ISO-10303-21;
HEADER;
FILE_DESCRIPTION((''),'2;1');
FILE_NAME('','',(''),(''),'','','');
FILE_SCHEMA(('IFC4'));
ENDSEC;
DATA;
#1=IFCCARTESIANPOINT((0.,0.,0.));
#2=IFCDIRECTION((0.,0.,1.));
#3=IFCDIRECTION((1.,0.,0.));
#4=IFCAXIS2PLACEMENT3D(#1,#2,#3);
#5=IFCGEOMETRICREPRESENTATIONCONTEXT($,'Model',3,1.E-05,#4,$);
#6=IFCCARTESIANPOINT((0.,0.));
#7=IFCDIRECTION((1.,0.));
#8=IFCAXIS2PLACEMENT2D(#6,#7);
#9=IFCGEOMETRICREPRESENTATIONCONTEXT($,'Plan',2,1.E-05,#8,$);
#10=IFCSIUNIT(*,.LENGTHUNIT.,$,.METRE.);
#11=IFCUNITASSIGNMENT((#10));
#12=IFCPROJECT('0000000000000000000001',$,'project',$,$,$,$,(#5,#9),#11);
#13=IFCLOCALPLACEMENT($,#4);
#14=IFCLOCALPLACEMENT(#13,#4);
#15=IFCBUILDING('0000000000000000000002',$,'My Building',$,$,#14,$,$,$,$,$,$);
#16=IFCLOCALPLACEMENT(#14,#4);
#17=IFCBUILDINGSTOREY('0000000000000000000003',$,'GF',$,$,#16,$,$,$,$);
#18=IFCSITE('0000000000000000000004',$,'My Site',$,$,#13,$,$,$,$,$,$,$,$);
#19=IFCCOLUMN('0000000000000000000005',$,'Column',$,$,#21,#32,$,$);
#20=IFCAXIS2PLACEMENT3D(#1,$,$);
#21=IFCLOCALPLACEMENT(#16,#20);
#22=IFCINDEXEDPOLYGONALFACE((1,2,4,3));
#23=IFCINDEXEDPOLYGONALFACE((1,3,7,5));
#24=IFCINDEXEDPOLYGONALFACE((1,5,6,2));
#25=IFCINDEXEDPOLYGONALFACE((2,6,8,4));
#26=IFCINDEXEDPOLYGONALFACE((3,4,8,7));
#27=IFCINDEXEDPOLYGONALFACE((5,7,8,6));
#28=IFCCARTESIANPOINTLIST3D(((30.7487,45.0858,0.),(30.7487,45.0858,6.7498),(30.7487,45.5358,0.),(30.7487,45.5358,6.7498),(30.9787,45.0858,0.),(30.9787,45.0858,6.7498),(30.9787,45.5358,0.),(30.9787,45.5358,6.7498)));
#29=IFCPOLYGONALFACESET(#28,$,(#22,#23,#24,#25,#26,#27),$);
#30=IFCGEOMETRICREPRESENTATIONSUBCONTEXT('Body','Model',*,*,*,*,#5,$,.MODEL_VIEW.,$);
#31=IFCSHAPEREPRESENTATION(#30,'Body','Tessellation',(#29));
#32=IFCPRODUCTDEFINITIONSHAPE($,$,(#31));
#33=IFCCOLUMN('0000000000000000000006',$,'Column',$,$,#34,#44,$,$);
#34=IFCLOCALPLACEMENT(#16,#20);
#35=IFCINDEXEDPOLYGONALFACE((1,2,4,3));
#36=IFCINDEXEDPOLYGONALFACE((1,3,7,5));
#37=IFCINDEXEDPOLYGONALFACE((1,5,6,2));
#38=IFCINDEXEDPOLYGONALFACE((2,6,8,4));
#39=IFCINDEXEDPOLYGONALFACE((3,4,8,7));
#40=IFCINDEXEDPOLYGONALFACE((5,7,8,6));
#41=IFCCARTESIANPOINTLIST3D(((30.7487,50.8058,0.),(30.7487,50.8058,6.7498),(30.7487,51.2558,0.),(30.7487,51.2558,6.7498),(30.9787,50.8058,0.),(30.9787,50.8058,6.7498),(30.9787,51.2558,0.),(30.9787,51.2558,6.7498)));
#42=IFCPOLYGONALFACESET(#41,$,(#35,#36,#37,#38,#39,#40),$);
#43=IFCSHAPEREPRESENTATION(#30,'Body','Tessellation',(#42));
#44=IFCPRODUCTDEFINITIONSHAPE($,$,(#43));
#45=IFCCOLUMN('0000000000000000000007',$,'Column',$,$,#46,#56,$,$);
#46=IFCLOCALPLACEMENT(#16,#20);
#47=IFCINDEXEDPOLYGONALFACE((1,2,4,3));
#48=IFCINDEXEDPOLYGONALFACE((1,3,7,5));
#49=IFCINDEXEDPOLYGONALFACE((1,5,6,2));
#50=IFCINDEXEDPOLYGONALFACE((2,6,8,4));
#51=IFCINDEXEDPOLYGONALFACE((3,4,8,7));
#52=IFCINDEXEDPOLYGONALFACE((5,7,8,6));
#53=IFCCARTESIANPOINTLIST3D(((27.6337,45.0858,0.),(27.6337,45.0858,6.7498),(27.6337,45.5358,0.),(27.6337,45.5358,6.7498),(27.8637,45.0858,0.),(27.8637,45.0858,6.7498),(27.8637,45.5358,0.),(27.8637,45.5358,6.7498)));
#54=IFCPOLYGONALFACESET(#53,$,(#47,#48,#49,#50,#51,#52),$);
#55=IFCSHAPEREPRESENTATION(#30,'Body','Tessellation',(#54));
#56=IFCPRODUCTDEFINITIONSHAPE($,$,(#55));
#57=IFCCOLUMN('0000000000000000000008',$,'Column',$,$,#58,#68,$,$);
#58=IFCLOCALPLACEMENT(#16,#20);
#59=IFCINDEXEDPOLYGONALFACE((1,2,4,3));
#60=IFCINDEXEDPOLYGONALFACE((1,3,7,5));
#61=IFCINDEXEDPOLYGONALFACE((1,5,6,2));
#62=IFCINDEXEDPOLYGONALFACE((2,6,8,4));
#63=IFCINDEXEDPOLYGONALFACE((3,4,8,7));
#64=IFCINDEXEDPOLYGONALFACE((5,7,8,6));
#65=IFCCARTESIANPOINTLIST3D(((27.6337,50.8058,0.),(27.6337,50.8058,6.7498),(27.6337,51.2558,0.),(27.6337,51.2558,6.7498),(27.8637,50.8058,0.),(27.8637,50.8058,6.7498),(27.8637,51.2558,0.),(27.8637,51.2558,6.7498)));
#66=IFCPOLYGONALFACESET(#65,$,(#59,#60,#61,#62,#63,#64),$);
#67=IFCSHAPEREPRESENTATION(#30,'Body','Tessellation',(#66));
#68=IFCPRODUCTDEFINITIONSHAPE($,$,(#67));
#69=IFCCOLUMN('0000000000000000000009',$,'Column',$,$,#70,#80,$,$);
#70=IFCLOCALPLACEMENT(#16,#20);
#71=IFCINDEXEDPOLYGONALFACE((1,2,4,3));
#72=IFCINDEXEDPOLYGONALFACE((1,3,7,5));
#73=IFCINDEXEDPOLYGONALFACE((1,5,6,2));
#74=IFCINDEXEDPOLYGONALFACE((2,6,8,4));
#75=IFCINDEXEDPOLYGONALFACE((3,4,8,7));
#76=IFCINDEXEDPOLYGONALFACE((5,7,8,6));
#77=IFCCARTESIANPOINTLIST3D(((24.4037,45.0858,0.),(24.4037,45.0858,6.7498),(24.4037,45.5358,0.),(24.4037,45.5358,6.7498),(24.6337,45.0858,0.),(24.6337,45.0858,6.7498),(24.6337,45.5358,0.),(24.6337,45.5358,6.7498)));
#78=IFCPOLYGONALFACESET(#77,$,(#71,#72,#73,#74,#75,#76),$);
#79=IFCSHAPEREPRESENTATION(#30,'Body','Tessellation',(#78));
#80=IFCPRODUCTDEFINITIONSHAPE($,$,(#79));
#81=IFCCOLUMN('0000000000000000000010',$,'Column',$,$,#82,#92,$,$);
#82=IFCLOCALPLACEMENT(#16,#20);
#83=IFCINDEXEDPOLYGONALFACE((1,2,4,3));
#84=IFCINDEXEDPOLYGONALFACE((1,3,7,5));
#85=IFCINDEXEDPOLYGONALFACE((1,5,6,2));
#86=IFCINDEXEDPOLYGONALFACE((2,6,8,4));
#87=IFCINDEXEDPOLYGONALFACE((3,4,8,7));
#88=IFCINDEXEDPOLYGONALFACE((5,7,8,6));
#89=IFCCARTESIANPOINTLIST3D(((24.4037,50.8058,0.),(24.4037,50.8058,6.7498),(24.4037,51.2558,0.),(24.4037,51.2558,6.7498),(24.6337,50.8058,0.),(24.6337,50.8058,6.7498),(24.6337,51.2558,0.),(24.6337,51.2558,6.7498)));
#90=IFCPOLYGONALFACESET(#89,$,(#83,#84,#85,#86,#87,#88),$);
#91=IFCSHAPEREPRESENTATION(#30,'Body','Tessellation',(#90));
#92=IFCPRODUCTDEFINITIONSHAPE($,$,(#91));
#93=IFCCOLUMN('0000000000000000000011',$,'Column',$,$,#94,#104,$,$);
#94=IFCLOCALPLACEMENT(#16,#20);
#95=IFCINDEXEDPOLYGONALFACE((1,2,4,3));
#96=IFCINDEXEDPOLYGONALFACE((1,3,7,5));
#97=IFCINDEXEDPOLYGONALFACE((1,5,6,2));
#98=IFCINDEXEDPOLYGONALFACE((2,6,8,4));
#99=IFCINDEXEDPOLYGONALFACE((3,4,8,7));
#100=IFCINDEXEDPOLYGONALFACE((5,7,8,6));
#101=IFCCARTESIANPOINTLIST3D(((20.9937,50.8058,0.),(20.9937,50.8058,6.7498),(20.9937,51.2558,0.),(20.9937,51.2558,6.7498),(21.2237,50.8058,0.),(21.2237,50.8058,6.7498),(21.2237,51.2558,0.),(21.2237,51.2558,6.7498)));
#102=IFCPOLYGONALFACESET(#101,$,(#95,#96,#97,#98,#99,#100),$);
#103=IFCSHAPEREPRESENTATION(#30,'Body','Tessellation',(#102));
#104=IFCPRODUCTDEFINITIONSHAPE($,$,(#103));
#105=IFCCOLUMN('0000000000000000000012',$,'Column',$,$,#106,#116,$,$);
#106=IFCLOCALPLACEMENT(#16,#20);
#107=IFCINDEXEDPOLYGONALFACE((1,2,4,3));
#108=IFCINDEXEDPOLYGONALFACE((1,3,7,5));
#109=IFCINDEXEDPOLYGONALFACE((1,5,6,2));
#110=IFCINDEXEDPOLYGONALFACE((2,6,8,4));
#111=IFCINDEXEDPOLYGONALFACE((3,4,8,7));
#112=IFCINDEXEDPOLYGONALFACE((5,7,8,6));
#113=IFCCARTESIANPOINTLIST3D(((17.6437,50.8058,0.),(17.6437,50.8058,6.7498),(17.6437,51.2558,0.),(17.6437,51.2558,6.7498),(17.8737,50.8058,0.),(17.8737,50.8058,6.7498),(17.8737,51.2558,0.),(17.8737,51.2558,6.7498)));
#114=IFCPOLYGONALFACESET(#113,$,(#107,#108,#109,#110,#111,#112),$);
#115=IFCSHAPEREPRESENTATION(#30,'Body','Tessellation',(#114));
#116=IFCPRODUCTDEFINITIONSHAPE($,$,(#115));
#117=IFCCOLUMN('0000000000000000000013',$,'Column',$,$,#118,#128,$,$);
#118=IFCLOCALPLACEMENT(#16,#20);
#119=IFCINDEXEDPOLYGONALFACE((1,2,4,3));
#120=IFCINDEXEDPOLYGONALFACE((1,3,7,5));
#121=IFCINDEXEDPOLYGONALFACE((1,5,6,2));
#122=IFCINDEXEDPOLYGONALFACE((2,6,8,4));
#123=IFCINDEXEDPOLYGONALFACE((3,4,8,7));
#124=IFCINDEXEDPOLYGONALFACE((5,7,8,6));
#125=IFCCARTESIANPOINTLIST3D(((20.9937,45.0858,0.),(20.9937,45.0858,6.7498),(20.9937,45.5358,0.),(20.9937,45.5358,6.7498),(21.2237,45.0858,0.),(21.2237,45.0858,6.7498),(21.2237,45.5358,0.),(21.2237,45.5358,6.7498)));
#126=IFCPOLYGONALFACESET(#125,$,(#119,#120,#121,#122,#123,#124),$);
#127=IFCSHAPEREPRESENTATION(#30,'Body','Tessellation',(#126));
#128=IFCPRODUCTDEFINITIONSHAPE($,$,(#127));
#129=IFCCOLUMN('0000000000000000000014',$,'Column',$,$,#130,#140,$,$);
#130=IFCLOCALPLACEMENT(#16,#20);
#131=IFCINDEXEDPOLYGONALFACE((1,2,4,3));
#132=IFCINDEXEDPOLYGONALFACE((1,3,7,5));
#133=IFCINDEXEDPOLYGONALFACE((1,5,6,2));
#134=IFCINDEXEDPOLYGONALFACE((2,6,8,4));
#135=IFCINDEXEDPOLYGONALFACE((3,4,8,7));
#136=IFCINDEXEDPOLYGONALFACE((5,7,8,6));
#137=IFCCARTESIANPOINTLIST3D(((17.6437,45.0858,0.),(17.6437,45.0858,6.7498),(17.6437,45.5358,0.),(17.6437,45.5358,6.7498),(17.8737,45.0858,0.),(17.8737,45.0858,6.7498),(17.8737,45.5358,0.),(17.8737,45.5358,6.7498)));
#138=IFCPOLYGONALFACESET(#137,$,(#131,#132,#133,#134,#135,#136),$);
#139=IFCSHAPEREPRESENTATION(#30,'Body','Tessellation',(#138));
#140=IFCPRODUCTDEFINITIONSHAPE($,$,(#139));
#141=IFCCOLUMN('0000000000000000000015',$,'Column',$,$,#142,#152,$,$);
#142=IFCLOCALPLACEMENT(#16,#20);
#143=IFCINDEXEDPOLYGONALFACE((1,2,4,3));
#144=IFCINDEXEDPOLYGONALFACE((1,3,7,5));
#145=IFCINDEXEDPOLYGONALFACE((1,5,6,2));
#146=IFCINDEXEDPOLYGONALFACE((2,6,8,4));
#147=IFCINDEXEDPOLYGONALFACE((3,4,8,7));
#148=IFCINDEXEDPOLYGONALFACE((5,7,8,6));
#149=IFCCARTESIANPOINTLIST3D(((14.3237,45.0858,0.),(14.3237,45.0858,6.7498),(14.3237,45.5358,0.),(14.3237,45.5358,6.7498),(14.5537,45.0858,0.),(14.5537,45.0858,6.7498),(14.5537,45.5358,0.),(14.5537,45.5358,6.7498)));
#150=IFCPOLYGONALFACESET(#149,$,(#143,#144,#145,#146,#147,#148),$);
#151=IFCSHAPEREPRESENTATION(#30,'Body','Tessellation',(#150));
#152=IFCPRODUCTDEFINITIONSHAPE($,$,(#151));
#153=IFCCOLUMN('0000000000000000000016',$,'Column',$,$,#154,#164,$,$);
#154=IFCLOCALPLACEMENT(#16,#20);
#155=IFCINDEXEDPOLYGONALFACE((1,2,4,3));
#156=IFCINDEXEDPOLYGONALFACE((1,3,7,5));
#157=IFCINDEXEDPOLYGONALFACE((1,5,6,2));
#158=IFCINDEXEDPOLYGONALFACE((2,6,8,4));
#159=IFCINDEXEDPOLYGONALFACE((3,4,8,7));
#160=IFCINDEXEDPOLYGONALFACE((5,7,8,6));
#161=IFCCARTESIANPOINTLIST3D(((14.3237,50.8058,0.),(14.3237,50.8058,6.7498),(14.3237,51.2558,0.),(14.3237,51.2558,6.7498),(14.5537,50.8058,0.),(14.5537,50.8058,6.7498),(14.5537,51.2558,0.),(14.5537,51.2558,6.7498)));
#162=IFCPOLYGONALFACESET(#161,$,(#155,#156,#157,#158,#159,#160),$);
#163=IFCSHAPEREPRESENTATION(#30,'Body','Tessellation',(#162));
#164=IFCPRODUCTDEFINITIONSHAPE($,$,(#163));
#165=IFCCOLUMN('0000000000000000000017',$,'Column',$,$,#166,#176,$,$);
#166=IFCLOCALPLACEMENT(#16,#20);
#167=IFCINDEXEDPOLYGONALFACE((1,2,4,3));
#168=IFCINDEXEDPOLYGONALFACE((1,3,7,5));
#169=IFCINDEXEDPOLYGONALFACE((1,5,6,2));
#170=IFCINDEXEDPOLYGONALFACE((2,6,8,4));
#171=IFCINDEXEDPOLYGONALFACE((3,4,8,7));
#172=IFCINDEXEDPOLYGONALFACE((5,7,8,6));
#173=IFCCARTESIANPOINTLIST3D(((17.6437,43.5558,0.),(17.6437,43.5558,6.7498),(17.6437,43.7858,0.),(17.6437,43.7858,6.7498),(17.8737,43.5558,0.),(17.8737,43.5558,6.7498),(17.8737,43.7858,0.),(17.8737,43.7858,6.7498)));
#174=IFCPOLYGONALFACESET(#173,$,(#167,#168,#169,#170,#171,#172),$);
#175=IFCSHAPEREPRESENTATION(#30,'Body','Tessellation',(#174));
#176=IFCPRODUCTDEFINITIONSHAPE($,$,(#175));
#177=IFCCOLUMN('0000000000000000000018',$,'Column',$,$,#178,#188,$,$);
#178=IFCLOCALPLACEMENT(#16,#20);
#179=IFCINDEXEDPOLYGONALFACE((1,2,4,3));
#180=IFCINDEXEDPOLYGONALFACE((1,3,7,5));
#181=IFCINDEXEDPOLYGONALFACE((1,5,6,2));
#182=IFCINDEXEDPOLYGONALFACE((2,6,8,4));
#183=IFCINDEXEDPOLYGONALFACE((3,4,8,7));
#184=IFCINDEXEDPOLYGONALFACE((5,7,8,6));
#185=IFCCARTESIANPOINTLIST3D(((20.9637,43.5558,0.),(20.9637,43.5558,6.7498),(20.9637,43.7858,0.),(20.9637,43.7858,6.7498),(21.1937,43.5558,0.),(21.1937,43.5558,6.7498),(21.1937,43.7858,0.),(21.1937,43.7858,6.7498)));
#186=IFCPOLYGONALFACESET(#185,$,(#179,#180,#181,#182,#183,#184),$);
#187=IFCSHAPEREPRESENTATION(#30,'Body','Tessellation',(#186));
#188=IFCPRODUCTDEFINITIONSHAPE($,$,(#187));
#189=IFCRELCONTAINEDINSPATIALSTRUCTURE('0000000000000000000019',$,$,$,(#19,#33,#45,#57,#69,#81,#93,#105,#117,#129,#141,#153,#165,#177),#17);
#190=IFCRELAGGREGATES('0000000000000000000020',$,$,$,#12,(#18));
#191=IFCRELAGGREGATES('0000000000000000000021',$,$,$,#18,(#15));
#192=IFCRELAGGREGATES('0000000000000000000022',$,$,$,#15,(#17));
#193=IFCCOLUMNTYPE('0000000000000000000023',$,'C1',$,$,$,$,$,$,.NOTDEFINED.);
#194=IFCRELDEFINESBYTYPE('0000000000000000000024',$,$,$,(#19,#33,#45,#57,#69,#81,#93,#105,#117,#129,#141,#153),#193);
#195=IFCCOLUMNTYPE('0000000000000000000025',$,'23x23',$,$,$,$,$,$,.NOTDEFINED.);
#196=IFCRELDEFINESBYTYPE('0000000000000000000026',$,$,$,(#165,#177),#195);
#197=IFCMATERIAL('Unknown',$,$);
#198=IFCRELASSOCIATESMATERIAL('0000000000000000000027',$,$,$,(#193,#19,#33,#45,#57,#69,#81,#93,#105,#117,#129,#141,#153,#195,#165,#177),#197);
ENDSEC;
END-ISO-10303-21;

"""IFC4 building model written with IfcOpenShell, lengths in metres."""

from ifc_helpers import new_model, si_unit, frame, origin_with_axes, origin_2d_with_axis, place, context, subcontext, project, spatial, rectangle, extrude, material, material_profile, profile_set, profile_usage, type_object, element, save


model = new_model("IFC4")

# Units and contexts
model_context = context("Model", 3, precision=1e-05, world=origin_with_axes())
plan_context = context("Plan", 2, precision=1e-05, world=origin_2d_with_axis())
body_context = subcontext(model_context, "Body", "Model", "MODEL_VIEW")
ifc_project = project(units=[si_unit("LENGTHUNIT", "METRE")], contexts=[model_context, plan_context])

# Site, building, storey
site_placement = place(None, origin_with_axes())
site = spatial("IfcSite", under=ifc_project, at=site_placement, Name="My Site")
building_placement = place(site_placement, origin_with_axes())
building = spatial("IfcBuilding", under=site, at=building_placement, Name="My Building")
storey_placement = place(building_placement, origin_with_axes())
storey = spatial("IfcBuildingStorey", under=building, at=storey_placement, Name="GF")

# Columns
ifc_material = material(Name="Unknown")
ifc_material_profile_1 = material_profile(ifc_material, rectangle(XDim=0.45, YDim=0.23))
ifc_profile_set_1 = profile_set([ifc_material_profile_1])
ifc_profile_usage_1 = profile_usage(ifc_profile_set_1, cardinal=5)
column_type_1 = type_object("IfcColumnType", Name="C1", PredefinedType="NOTDEFINED", material=ifc_profile_set_1)
column_1_placement = place(storey_placement, frame((30.8637, 45.3108, 0.0), z_axis=(0.0, 0.0, 1.0), x_axis=(0.0, 1.0, 0.0)))
element("IfcColumn", 1, at=column_1_placement, inside=storey, type_object=column_type_1, material=ifc_profile_usage_1, Name="Column", context=body_context, shape_type="SweptSolid", body=[
    extrude(rectangle(XDim=0.45, YDim=0.23), origin_with_axes(), (0.0, 0.0, 1.0), 6.7498),
])
ifc_profile_usage_2 = profile_usage(ifc_profile_set_1, cardinal=5)
column_2_placement = place(storey_placement, frame((30.8637, 51.0308, 0.0), z_axis=(0.0, 0.0, 1.0), x_axis=(0.0, 1.0, 0.0)))
element("IfcColumn", 2, at=column_2_placement, inside=storey, type_object=column_type_1, material=ifc_profile_usage_2, Name="Column", context=body_context, shape_type="SweptSolid", body=[
    extrude(rectangle(XDim=0.45, YDim=0.23), origin_with_axes(), (0.0, 0.0, 1.0), 6.7498),
])
ifc_profile_usage_3 = profile_usage(ifc_profile_set_1, cardinal=5)
column_3_placement = place(storey_placement, frame((27.7487, 45.3108, 0.0), z_axis=(0.0, 0.0, 1.0), x_axis=(0.0, 1.0, 0.0)))
element("IfcColumn", 3, at=column_3_placement, inside=storey, type_object=column_type_1, material=ifc_profile_usage_3, Name="Column", context=body_context, shape_type="SweptSolid", body=[
    extrude(rectangle(XDim=0.45, YDim=0.23), origin_with_axes(), (0.0, 0.0, 1.0), 6.7498),
])
ifc_profile_usage_4 = profile_usage(ifc_profile_set_1, cardinal=5)
column_4_placement = place(storey_placement, frame((27.7487, 51.0308, 0.0), z_axis=(0.0, 0.0, 1.0), x_axis=(0.0, 1.0, 0.0)))
element("IfcColumn", 4, at=column_4_placement, inside=storey, type_object=column_type_1, material=ifc_profile_usage_4, Name="Column", context=body_context, shape_type="SweptSolid", body=[
    extrude(rectangle(XDim=0.45, YDim=0.23), origin_with_axes(), (0.0, 0.0, 1.0), 6.7498),
])
ifc_profile_usage_5 = profile_usage(ifc_profile_set_1, cardinal=5)
column_5_placement = place(storey_placement, frame((24.5187, 45.3108, 0.0), z_axis=(0.0, 0.0, 1.0), x_axis=(0.0, 1.0, 0.0)))
element("IfcColumn", 5, at=column_5_placement, inside=storey, type_object=column_type_1, material=ifc_profile_usage_5, Name="Column", context=body_context, shape_type="SweptSolid", body=[
    extrude(rectangle(XDim=0.45, YDim=0.23), origin_with_axes(), (0.0, 0.0, 1.0), 6.7498),
])
ifc_profile_usage_6 = profile_usage(ifc_profile_set_1, cardinal=5)
column_6_placement = place(storey_placement, frame((24.5187, 51.0308, 0.0), z_axis=(0.0, 0.0, 1.0), x_axis=(0.0, 1.0, 0.0)))
element("IfcColumn", 6, at=column_6_placement, inside=storey, type_object=column_type_1, material=ifc_profile_usage_6, Name="Column", context=body_context, shape_type="SweptSolid", body=[
    extrude(rectangle(XDim=0.45, YDim=0.23), origin_with_axes(), (0.0, 0.0, 1.0), 6.7498),
])
ifc_profile_usage_7 = profile_usage(ifc_profile_set_1, cardinal=5)
column_7_placement = place(storey_placement, frame((21.1087, 51.0308, 0.0), z_axis=(0.0, 0.0, 1.0), x_axis=(0.0, 1.0, 0.0)))
element("IfcColumn", 7, at=column_7_placement, inside=storey, type_object=column_type_1, material=ifc_profile_usage_7, Name="Column", context=body_context, shape_type="SweptSolid", body=[
    extrude(rectangle(XDim=0.45, YDim=0.23), origin_with_axes(), (0.0, 0.0, 1.0), 6.7498),
])
ifc_profile_usage_8 = profile_usage(ifc_profile_set_1, cardinal=5)
column_8_placement = place(storey_placement, frame((17.7587, 51.0308, 0.0), z_axis=(0.0, 0.0, 1.0), x_axis=(0.0, 1.0, 0.0)))
element("IfcColumn", 8, at=column_8_placement, inside=storey, type_object=column_type_1, material=ifc_profile_usage_8, Name="Column", context=body_context, shape_type="SweptSolid", body=[
    extrude(rectangle(XDim=0.45, YDim=0.23), origin_with_axes(), (0.0, 0.0, 1.0), 6.7498),
])
ifc_profile_usage_9 = profile_usage(ifc_profile_set_1, cardinal=5)
column_9_placement = place(storey_placement, frame((21.1087, 45.3108, 0.0), z_axis=(0.0, 0.0, 1.0), x_axis=(0.0, 1.0, 0.0)))
element("IfcColumn", 9, at=column_9_placement, inside=storey, type_object=column_type_1, material=ifc_profile_usage_9, Name="Column", context=body_context, shape_type="SweptSolid", body=[
    extrude(rectangle(XDim=0.45, YDim=0.23), origin_with_axes(), (0.0, 0.0, 1.0), 6.7498),
])
ifc_profile_usage_10 = profile_usage(ifc_profile_set_1, cardinal=5)
column_10_placement = place(storey_placement, frame((17.7587, 45.3108, 0.0), z_axis=(0.0, 0.0, 1.0), x_axis=(0.0, 1.0, 0.0)))
element("IfcColumn", 10, at=column_10_placement, inside=storey, type_object=column_type_1, material=ifc_profile_usage_10, Name="Column", context=body_context, shape_type="SweptSolid", body=[
    extrude(rectangle(XDim=0.45, YDim=0.23), origin_with_axes(), (0.0, 0.0, 1.0), 6.7498),
])
ifc_profile_usage_11 = profile_usage(ifc_profile_set_1, cardinal=5)
column_11_placement = place(storey_placement, frame((14.4387, 45.3108, 0.0), z_axis=(0.0, 0.0, 1.0), x_axis=(0.0, 1.0, 0.0)))
element("IfcColumn", 11, at=column_11_placement, inside=storey, type_object=column_type_1, material=ifc_profile_usage_11, Name="Column", context=body_context, shape_type="SweptSolid", body=[
    extrude(rectangle(XDim=0.45, YDim=0.23), origin_with_axes(), (0.0, 0.0, 1.0), 6.7498),
])
ifc_profile_usage_12 = profile_usage(ifc_profile_set_1, cardinal=5)
column_12_placement = place(storey_placement, frame((14.4387, 51.0308, 0.0), z_axis=(0.0, 0.0, 1.0), x_axis=(0.0, 1.0, 0.0)))
element("IfcColumn", 12, at=column_12_placement, inside=storey, type_object=column_type_1, material=ifc_profile_usage_12, Name="Column", context=body_context, shape_type="SweptSolid", body=[
    extrude(rectangle(XDim=0.45, YDim=0.23), origin_with_axes(), (0.0, 0.0, 1.0), 6.7498),
])
ifc_material_profile_2 = material_profile(ifc_material, rectangle(XDim=0.23, YDim=0.23))
ifc_profile_set_2 = profile_set([ifc_material_profile_2])
ifc_profile_usage_13 = profile_usage(ifc_profile_set_2, cardinal=5)
column_type_2 = type_object("IfcColumnType", Name="23x23", PredefinedType="NOTDEFINED", material=ifc_profile_set_2)
column_13_placement = place(storey_placement, frame((17.7587, 43.6708, 0.0), z_axis=(0.0, 0.0, 1.0), x_axis=(1.0, 0.0, 0.0)))
element("IfcColumn", 13, at=column_13_placement, inside=storey, type_object=column_type_2, material=ifc_profile_usage_13, Name="Column", context=body_context, shape_type="SweptSolid", body=[
    extrude(rectangle(XDim=0.23, YDim=0.23), origin_with_axes(), (0.0, 0.0, 1.0), 6.7498),
])
ifc_profile_usage_14 = profile_usage(ifc_profile_set_2, cardinal=5)
column_14_placement = place(storey_placement, frame((21.0787, 43.6708, 0.0), z_axis=(0.0, 0.0, 1.0), x_axis=(1.0, 0.0, 0.0)))
element("IfcColumn", 14, at=column_14_placement, inside=storey, type_object=column_type_2, material=ifc_profile_usage_14, Name="Column", context=body_context, shape_type="SweptSolid", body=[
    extrude(rectangle(XDim=0.23, YDim=0.23), origin_with_axes(), (0.0, 0.0, 1.0), 6.7498),
])

save(model, "model.ifc")
